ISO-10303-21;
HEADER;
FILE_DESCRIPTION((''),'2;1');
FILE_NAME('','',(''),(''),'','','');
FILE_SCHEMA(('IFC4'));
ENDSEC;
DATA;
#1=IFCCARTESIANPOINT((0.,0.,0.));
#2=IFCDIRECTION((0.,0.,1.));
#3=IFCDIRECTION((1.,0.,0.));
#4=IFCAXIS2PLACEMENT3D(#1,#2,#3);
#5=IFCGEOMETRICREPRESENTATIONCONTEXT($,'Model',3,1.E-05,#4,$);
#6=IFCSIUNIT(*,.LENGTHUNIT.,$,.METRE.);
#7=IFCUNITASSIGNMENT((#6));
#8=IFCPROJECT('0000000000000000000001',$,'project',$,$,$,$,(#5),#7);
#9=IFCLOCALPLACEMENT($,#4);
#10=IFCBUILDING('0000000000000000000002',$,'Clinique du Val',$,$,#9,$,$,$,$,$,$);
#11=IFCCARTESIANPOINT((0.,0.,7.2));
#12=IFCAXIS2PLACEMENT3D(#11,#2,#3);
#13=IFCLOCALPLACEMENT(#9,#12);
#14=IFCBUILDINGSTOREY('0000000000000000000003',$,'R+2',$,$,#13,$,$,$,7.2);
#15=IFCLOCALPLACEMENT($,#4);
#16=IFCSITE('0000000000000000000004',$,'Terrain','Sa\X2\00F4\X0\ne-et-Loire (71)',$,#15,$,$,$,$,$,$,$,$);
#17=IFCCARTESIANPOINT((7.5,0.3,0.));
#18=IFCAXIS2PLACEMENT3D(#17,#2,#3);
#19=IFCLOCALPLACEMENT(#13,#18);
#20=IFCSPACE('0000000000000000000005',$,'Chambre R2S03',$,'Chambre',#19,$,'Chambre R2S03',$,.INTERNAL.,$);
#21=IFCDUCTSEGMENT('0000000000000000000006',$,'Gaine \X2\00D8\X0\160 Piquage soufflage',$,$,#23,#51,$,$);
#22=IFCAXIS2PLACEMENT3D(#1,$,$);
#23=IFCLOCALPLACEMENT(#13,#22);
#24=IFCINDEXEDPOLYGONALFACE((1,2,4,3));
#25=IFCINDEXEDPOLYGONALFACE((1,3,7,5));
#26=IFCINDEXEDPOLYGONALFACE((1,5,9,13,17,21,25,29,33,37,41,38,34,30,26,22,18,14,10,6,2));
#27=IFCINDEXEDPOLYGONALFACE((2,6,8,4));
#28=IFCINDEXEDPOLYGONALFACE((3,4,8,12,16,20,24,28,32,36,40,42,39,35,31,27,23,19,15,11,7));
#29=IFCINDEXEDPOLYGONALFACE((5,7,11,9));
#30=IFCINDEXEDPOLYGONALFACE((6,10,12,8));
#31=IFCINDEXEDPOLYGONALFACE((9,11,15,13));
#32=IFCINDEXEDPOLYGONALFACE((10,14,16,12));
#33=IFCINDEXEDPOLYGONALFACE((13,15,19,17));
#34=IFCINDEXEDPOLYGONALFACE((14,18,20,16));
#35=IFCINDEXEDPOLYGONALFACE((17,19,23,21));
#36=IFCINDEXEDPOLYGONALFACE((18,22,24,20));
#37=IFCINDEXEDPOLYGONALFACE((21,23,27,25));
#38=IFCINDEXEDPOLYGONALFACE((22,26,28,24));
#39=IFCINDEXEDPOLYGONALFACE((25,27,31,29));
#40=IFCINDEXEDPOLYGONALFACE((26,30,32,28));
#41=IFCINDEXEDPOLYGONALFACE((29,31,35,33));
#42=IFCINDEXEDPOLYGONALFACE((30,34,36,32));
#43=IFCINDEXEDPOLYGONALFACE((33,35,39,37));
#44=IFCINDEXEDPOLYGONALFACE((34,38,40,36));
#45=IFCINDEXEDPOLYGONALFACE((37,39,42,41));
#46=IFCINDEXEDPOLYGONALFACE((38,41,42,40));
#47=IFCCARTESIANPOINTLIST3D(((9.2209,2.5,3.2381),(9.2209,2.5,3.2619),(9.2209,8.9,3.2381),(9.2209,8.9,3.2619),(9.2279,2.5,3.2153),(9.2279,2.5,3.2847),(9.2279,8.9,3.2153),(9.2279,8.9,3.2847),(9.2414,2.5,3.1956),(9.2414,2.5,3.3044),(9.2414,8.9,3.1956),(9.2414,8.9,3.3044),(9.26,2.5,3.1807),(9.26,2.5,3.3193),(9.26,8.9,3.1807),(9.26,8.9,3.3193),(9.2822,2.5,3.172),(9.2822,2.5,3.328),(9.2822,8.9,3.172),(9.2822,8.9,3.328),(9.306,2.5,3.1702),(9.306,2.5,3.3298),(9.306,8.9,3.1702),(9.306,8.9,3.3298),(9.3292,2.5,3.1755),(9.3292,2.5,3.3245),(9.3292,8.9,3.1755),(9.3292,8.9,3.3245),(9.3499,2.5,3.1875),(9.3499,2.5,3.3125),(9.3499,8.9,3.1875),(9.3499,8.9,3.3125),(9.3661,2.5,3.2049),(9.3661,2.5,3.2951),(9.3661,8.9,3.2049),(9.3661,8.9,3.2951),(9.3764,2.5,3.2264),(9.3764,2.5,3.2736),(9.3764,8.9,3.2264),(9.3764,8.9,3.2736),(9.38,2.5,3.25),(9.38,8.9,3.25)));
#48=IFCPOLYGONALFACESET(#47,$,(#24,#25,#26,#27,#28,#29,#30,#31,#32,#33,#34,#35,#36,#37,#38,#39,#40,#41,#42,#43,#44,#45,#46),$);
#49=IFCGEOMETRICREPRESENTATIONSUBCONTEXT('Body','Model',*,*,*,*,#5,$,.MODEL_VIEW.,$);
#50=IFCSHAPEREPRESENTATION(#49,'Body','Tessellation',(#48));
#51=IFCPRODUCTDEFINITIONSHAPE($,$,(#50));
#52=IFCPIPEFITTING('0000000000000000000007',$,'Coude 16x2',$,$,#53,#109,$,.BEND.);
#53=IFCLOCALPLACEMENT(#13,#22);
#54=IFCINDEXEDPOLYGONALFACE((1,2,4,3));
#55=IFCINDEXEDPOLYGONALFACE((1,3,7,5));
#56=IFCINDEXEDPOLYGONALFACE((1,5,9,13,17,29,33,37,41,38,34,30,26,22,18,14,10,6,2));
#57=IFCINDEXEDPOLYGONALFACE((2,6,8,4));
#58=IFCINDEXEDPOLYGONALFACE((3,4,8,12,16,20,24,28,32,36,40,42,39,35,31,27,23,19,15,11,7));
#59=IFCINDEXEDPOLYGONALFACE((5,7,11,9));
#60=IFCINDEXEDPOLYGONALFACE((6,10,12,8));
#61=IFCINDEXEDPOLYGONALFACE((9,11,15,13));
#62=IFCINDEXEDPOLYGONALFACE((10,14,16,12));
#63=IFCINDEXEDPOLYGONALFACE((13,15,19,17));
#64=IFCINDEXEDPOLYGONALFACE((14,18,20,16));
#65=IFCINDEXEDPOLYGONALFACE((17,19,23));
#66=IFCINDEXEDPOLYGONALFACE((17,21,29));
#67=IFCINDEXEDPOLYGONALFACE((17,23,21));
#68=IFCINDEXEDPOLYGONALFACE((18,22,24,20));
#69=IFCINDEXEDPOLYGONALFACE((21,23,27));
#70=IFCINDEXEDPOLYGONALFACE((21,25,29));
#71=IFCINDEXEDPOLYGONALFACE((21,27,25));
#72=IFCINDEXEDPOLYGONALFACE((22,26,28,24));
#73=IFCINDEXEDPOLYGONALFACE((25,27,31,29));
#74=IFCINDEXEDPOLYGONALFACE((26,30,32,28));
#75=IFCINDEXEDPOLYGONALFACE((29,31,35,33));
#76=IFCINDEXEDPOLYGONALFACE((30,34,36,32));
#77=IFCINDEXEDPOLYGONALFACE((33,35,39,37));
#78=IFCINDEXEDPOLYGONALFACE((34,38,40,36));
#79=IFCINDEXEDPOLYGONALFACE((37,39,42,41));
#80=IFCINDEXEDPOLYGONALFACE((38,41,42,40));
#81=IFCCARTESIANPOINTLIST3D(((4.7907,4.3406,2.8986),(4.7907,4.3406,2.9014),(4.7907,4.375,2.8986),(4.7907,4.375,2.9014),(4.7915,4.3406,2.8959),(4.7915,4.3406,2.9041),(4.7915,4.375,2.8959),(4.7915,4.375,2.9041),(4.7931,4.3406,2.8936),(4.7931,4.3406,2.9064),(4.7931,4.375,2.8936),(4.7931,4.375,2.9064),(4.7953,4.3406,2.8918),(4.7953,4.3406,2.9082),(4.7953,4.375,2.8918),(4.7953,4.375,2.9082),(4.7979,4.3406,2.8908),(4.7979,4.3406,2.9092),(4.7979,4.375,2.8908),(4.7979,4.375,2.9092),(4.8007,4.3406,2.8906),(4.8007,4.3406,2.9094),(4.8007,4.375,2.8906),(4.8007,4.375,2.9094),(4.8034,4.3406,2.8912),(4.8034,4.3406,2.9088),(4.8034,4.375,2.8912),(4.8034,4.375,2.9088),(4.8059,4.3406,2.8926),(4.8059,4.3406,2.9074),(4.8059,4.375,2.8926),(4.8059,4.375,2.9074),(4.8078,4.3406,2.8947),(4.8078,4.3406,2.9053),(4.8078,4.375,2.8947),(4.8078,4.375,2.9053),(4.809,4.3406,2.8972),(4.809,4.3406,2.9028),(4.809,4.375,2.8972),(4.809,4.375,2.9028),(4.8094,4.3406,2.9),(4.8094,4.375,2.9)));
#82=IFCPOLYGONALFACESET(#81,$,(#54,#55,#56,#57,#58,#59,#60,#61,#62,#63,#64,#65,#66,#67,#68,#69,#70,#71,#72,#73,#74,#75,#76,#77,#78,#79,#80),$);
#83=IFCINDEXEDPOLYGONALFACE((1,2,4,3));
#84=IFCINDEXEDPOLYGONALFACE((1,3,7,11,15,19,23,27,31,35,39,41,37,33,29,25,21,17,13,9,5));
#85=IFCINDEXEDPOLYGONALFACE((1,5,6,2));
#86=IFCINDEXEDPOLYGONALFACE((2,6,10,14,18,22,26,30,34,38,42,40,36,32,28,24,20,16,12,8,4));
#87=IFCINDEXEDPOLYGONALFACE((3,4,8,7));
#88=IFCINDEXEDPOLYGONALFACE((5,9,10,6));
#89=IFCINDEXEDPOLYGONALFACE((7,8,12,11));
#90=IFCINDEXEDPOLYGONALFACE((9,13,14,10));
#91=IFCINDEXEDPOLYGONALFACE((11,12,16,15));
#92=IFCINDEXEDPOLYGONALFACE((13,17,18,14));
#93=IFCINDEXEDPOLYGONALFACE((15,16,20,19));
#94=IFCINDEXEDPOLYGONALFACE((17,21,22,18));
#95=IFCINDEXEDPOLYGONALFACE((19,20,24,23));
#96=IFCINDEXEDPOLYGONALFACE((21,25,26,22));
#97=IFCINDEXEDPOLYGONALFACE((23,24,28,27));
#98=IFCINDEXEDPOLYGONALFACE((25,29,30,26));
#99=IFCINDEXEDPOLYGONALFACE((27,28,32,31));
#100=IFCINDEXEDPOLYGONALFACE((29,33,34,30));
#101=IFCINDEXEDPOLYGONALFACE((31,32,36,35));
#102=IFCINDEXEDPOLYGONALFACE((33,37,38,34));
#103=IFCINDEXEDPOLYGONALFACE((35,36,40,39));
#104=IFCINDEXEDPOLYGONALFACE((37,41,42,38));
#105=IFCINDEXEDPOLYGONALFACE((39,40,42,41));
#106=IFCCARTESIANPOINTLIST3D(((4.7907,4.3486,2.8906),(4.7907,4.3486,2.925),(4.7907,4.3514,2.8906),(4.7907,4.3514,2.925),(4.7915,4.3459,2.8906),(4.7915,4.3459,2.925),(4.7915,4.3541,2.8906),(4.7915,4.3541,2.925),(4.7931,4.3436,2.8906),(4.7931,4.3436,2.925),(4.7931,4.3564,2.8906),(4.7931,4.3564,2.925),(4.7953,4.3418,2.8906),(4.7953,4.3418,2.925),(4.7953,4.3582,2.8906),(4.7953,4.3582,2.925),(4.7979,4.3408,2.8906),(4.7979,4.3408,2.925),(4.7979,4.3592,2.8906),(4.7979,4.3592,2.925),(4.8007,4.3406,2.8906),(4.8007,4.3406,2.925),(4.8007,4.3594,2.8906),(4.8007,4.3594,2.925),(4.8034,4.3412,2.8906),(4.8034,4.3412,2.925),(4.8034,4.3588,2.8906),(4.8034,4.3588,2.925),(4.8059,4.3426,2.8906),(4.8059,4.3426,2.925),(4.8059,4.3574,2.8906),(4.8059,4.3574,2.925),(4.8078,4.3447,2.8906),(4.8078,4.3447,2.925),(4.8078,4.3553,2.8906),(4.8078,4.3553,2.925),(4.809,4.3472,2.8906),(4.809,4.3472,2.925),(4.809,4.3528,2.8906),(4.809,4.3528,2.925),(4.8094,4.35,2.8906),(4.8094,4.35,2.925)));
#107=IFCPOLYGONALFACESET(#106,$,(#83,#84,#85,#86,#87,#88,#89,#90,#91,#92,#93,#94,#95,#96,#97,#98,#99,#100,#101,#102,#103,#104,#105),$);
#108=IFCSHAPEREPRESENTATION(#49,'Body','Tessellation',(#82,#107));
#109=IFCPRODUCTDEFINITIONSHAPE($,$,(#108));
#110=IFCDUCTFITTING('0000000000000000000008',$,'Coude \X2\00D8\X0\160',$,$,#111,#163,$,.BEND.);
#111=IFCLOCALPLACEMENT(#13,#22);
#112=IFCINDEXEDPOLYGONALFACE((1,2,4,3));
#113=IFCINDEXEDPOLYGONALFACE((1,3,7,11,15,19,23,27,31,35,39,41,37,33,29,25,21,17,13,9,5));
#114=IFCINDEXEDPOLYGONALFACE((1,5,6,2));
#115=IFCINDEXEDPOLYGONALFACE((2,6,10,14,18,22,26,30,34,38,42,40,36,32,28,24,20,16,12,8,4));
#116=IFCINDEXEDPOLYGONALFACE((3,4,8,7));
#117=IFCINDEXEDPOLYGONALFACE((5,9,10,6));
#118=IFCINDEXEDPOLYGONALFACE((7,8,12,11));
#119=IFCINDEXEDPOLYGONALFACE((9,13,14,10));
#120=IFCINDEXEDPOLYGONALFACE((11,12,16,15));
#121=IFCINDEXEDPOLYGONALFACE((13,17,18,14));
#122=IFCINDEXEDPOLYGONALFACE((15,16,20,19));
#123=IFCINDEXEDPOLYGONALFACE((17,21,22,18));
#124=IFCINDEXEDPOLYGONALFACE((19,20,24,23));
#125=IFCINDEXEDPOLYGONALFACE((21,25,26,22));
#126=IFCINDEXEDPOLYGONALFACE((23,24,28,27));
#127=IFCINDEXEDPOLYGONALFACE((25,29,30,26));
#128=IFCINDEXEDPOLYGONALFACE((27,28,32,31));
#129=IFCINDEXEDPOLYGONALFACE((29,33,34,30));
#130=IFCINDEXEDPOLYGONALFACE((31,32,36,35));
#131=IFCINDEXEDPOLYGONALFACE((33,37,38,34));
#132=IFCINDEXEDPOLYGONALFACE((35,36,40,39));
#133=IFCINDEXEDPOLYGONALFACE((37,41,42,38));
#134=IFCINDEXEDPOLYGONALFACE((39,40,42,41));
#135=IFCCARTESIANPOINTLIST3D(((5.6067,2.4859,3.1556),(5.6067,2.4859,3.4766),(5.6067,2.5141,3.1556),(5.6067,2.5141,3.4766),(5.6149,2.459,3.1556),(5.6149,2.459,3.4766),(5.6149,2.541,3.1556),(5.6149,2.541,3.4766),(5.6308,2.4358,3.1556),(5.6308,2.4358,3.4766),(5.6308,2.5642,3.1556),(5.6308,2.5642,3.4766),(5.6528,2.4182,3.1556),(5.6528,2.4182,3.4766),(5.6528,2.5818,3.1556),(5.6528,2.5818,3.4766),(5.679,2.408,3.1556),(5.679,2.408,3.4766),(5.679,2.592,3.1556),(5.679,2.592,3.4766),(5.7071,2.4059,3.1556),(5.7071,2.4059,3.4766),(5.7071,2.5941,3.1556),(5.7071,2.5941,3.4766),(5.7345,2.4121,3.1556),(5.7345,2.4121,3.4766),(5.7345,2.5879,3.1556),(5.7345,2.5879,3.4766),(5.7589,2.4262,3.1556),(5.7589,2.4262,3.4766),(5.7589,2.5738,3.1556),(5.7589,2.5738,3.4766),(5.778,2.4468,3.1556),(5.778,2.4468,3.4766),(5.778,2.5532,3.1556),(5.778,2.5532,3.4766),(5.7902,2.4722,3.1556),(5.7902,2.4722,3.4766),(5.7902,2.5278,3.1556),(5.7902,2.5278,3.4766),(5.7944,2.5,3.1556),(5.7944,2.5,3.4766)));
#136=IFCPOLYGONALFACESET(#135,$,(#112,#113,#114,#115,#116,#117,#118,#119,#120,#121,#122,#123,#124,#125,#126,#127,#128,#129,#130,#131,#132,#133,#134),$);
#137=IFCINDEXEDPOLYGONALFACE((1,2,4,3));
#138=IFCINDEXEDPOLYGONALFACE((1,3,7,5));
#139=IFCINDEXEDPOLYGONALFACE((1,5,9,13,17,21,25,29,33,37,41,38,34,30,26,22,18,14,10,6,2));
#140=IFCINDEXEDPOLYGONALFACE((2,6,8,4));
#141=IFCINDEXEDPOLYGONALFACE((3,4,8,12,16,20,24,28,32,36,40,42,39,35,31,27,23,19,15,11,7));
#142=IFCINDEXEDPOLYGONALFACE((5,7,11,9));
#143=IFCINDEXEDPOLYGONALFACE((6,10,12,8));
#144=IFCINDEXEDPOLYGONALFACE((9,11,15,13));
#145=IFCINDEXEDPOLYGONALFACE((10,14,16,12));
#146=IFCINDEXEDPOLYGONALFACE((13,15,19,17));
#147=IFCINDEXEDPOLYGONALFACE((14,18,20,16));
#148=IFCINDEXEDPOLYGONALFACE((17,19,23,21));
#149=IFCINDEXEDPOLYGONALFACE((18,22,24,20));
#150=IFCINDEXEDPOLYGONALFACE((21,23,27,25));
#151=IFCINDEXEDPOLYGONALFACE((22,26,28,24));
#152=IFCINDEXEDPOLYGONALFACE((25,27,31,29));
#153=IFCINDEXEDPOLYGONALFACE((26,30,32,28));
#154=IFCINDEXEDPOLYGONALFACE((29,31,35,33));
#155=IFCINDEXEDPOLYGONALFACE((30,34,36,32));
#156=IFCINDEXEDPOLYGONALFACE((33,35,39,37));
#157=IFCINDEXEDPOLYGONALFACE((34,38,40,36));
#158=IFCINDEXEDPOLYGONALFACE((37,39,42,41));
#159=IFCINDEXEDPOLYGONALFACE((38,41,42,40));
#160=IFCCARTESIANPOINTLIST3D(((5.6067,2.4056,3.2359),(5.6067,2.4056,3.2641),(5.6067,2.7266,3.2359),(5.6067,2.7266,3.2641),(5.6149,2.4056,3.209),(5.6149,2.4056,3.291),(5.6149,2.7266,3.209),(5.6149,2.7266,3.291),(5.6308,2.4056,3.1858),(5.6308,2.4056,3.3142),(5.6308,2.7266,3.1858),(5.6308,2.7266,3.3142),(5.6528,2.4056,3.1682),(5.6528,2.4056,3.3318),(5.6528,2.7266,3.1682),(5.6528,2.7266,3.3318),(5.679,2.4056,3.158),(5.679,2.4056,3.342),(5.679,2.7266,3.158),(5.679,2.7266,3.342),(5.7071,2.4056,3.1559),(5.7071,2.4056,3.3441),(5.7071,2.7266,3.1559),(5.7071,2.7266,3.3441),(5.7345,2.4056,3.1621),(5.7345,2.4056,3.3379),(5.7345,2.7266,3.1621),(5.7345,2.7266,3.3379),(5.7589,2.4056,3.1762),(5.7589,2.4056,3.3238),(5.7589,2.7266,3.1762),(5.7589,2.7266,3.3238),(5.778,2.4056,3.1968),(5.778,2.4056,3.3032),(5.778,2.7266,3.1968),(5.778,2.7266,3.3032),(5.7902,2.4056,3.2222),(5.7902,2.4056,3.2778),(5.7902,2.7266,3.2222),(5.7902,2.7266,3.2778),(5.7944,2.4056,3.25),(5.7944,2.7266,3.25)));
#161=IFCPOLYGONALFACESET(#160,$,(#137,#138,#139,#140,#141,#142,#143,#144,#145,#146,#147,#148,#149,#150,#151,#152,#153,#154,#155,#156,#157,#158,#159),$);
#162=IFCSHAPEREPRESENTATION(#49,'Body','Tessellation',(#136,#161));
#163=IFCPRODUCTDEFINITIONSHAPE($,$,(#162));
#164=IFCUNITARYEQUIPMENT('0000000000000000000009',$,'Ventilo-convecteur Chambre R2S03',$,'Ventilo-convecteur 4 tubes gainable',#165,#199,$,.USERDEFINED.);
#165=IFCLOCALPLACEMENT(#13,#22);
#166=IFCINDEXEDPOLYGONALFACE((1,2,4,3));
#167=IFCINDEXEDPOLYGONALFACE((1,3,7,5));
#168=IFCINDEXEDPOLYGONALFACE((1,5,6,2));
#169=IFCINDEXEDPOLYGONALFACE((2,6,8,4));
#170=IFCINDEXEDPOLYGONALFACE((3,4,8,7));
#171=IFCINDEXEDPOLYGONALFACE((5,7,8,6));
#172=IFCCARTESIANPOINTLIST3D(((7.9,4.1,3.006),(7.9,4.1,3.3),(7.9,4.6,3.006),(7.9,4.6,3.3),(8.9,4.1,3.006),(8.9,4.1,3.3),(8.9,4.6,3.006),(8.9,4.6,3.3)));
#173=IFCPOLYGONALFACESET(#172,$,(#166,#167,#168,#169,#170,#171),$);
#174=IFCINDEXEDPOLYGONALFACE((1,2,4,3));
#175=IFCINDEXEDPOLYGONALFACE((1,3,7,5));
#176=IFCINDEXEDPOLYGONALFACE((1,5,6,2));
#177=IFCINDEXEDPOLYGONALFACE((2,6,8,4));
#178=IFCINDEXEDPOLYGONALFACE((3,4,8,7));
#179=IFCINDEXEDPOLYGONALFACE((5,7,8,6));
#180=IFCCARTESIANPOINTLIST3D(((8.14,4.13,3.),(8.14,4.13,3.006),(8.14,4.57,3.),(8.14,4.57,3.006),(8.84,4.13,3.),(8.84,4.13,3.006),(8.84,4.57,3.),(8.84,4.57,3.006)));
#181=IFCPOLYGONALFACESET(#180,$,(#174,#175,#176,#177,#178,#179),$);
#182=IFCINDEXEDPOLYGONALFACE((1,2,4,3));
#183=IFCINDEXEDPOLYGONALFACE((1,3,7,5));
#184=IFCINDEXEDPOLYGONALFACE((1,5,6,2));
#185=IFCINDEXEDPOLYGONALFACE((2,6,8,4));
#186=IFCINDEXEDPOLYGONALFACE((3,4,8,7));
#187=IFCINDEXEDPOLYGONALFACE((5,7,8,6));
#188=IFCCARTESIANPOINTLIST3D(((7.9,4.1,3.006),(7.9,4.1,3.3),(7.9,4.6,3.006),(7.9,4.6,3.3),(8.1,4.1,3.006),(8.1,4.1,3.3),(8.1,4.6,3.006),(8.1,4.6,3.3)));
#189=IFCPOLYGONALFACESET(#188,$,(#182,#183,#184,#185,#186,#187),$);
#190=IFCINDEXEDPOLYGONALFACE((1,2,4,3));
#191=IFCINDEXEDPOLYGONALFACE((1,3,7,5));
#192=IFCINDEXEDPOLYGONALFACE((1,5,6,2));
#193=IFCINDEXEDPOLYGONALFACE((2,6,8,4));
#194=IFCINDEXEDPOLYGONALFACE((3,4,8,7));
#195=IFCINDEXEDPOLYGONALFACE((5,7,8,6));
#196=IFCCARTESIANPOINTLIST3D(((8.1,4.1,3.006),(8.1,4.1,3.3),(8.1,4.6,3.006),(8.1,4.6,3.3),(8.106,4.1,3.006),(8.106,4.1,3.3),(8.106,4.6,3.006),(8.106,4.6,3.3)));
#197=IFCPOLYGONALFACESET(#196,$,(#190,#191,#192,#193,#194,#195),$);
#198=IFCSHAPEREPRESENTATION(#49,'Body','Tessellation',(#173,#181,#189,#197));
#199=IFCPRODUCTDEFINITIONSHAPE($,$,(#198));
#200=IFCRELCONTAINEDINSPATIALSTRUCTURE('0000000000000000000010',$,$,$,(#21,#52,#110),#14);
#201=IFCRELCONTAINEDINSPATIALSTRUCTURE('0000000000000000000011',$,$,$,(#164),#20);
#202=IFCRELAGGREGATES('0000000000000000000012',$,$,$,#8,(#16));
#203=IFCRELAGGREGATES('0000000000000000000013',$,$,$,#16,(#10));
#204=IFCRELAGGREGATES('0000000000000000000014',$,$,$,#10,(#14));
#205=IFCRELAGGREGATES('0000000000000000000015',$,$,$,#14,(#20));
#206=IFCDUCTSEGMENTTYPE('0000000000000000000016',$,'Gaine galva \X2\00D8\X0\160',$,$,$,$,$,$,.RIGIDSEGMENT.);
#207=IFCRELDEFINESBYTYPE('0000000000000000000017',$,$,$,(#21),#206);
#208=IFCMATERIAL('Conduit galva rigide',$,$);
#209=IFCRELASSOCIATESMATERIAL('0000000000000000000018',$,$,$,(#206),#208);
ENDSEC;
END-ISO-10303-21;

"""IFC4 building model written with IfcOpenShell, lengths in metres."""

from ifc_helpers import new_model, si_unit, frame, frame_2d, origin_with_axes, place, context, subcontext, project, spatial, rectangle, circle, extrude, material, type_object, element, save


model = new_model("IFC4")

# Units and contexts
model_context = context("Model", 3, precision=1e-05, world=origin_with_axes())
body_context = subcontext(model_context, "Body", "Model", "MODEL_VIEW")
ifc_project = project(units=[si_unit("LENGTHUNIT", "METRE")], contexts=[model_context])

# Site, building, storey
site_placement = place(None, origin_with_axes())
site = spatial("IfcSite", under=ifc_project, at=site_placement, Name="Terrain", Description="Saône-et-Loire (71)")
building_placement = place(None, origin_with_axes())
building = spatial("IfcBuilding", under=site, at=building_placement, Name="Clinique du Val")
storey_placement = place(building_placement, frame((0.0, 0.0, 7.2), z_axis=(0.0, 0.0, 1.0), x_axis=(1.0, 0.0, 0.0)))
storey = spatial("IfcBuildingStorey", under=building, at=storey_placement, Name="R+2", Elevation=7.2)

# Duct segment
ifc_material_1 = material(Name="Conduit galva rigide")
duct_segment_type = type_object("IfcDuctSegmentType", Name="Gaine galva Ø160", PredefinedType="RIGIDSEGMENT", material=ifc_material_1)
duct_segment_1_placement = place(storey_placement, frame((9.3, 2.5, 3.25), z_axis=(0.0, 1.0, 0.0), x_axis=(1.0, 0.0, 0.0)))
element("IfcDuctSegment", 1, at=duct_segment_1_placement, inside=storey, type_object=duct_segment_type, Name="Gaine Ø160 Piquage soufflage", context=body_context, shape_type="SweptSolid", body=[
    extrude(circle(Radius=0.08), origin_with_axes(), (0.0, 0.0, 1.0), 6.4),
])

# Pipe fitting
pipe_fitting_placement = place(storey_placement, frame((4.8, 4.35, 2.9), z_axis=(0.0, 0.0, 1.0), x_axis=(1.0, 0.0, 0.0)))
element("IfcPipeFitting", 2, at=pipe_fitting_placement, inside=storey, Name="Coude 16x2", PredefinedType="BEND", context=body_context, shape_type="SweptSolid", body=[
    extrude(circle(Radius=0.0094), frame((0.0, -0.0094, 0.0), z_axis=(0.0, 1.0, 0.0), x_axis=(1.0, 0.0, 0.0)), (0.0, 0.0, 1.0), 0.0344),
    extrude(circle(Radius=0.0094), frame((0.0, 0.0, -0.0094), z_axis=(0.0, 0.0, 1.0), x_axis=(1.0, 0.0, 0.0)), (0.0, 0.0, 1.0), 0.0344),
])

# Duct fitting
duct_fitting_1_placement = place(storey_placement, frame((5.7, 2.5, 3.25), z_axis=(0.0, 0.0, 1.0), x_axis=(1.0, 0.0, 0.0)))
element("IfcDuctFitting", 3, at=duct_fitting_1_placement, inside=storey, Name="Coude Ø160", PredefinedType="BEND", context=body_context, shape_type="SweptSolid", body=[
    extrude(circle(Radius=0.0944), frame((0.0, 0.0, -0.0944), z_axis=(0.0, 0.0, 1.0), x_axis=(1.0, 0.0, 0.0)), (0.0, 0.0, 1.0), 0.321),
    extrude(circle(Radius=0.0944), frame((0.0, -0.0944, 0.0), z_axis=(0.0, 1.0, 0.0), x_axis=(1.0, 0.0, 0.0)), (0.0, 0.0, 1.0), 0.321),
])

# Shared definitions
space_1_placement = place(storey_placement, frame((7.5, 0.3, 0.0), z_axis=(0.0, 0.0, 1.0), x_axis=(1.0, 0.0, 0.0)))
space_1 = spatial("IfcSpace", under=storey, at=space_1_placement, Name="Chambre R2S03", ObjectType="Chambre", LongName="Chambre R2S03", PredefinedType="INTERNAL")

# Unitary equipment
unitary_equipment_placement = place(space_1_placement, frame((0.4, 3.8, 3.0), z_axis=(0.0, 0.0, 1.0), x_axis=(1.0, 0.0, 0.0)))
element("IfcUnitaryEquipment", 4, at=unitary_equipment_placement, inside=space_1, Name="Ventilo-convecteur Chambre R2S03", ObjectType="Ventilo-convecteur 4 tubes gainable", PredefinedType="USERDEFINED", context=body_context, shape_type="SweptSolid", body=[
    extrude(rectangle(XDim=1.0, YDim=0.5, at=frame_2d((0.5, 0.25))), frame((0.0, 0.0, 0.006), z_axis=(0.0, 0.0, 1.0), x_axis=(1.0, 0.0, 0.0)), (0.0, 0.0, 1.0), 0.294),
    extrude(rectangle(XDim=0.7, YDim=0.44, at=frame_2d((0.35, 0.22))), frame((0.24, 0.03, 0.0), z_axis=(0.0, 0.0, 1.0), x_axis=(1.0, 0.0, 0.0)), (0.0, 0.0, 1.0), 0.006),
    extrude(rectangle(XDim=0.2, YDim=0.5, at=frame_2d((0.1, 0.25))), frame((0.0, 0.0, 0.006), z_axis=(0.0, 0.0, 1.0), x_axis=(1.0, 0.0, 0.0)), (0.0, 0.0, 1.0), 0.294),
    extrude(rectangle(XDim=0.006, YDim=0.5, at=frame_2d((0.003, 0.25))), frame((0.2, 0.0, 0.006), z_axis=(0.0, 0.0, 1.0), x_axis=(1.0, 0.0, 0.0)), (0.0, 0.0, 1.0), 0.294),
])

save(model, "model.ifc")
